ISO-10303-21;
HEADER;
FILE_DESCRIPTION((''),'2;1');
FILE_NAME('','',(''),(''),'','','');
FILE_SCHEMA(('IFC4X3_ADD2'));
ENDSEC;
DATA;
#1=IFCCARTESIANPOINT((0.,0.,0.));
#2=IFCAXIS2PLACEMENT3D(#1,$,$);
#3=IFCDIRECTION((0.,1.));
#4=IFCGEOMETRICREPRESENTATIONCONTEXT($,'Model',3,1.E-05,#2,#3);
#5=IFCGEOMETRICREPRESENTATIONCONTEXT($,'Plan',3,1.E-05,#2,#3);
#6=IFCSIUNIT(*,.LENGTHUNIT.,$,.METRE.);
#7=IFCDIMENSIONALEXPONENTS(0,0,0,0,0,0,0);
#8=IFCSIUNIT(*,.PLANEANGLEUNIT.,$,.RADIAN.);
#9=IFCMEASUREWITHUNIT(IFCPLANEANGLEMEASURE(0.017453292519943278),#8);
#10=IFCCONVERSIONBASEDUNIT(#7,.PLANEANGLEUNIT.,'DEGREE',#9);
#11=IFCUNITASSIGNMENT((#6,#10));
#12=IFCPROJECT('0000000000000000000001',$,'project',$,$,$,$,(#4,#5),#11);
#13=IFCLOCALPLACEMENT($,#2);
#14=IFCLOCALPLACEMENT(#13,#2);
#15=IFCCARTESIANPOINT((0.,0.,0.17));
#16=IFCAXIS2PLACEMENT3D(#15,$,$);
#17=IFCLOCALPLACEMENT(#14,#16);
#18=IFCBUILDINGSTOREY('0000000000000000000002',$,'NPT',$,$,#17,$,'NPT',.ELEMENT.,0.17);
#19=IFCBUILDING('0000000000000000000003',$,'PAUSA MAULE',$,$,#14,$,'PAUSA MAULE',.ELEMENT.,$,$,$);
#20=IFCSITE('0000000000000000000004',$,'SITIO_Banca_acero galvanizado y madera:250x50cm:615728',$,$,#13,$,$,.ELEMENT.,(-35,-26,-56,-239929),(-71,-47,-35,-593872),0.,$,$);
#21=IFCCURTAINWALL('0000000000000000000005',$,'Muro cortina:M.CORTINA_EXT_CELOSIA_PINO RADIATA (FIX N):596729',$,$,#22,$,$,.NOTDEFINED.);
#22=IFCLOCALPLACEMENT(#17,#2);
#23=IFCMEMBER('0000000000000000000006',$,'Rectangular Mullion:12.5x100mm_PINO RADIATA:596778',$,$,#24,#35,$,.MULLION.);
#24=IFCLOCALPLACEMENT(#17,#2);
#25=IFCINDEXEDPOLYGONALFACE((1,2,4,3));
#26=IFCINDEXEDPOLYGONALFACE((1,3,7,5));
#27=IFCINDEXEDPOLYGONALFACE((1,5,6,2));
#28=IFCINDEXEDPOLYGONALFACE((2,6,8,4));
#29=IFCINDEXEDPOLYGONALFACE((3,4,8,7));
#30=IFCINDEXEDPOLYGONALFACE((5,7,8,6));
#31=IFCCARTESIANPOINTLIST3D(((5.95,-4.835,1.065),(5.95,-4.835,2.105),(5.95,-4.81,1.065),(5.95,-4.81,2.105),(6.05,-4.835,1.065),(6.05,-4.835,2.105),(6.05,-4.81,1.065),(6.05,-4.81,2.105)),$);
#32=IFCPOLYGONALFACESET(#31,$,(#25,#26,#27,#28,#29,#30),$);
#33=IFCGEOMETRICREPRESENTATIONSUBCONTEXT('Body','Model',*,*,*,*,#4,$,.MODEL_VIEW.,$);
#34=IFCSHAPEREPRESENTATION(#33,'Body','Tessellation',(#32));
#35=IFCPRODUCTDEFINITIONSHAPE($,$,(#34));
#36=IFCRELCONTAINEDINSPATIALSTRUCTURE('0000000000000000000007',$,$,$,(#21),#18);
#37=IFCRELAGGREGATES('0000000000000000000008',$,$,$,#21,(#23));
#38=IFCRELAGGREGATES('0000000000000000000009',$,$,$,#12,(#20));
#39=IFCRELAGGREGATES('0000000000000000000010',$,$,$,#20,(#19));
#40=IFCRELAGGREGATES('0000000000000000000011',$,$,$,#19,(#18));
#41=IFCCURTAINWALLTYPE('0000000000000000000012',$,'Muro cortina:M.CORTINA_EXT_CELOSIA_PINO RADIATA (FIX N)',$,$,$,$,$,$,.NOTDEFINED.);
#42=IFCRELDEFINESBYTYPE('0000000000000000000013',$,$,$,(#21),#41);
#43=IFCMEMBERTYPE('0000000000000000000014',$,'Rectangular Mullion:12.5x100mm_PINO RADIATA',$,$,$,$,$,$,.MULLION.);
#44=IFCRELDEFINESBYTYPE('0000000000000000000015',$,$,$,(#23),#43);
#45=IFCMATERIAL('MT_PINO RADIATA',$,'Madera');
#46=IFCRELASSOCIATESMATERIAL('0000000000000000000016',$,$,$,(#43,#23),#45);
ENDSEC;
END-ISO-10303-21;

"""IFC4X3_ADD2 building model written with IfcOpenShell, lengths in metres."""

from ifc_helpers import new_model, entity, si_unit, converted_unit, direction, frame, frame_2d, origin, origin_2d_with_axis, place, context, subcontext, project, spatial, rectangle, extrude, source, transform, mapped, material, material_profile, profile_set, profile_usage, type_object, type_shapes, element, aggregate, save


model = new_model("IFC4X3_ADD2")

# Units and contexts
model_context = context("Model", 3, precision=1e-05, world=origin(), true_north=direction((0.0, 1.0)))
plan_context = context("Plan", 3, precision=1e-05, world=origin(), true_north=direction((0.0, 1.0)))
body_context = subcontext(model_context, "Body", "Model", "MODEL_VIEW")
ifc_project = project(units=[si_unit("LENGTHUNIT", "METRE"), converted_unit("PLANEANGLEUNIT", "DEGREE", entity("IfcPlaneAngleMeasure", 0.017453292519943278), si_unit("PLANEANGLEUNIT", "RADIAN"), dimensions=[0, 0, 0, 0, 0, 0, 0])], contexts=[model_context, plan_context])

# Site, building, storey
site_placement = place(None, origin())
site = spatial("IfcSite", under=ifc_project, at=site_placement, Name="SITIO_Banca_acero galvanizado y madera:250x50cm:615728", CompositionType="ELEMENT", RefLatitude=(-35, -26, -56, -239929), RefLongitude=(-71, -47, -35, -593872), RefElevation=0.0)
building_placement = place(site_placement, origin())
building = spatial("IfcBuilding", under=site, at=building_placement, Name="PAUSA MAULE", LongName="PAUSA MAULE", CompositionType="ELEMENT")
storey_placement = place(building_placement, frame((0.0, 0.0, 0.17)))
storey = spatial("IfcBuildingStorey", under=building, at=storey_placement, Name="NPT", LongName="NPT", CompositionType="ELEMENT", Elevation=0.17)

# Curtain wall
curtain_wall_type = type_object("IfcCurtainWallType", Name="Muro cortina:M.CORTINA_EXT_CELOSIA_PINO RADIATA (FIX N)", PredefinedType="NOTDEFINED")
curtain_wall_1_placement = place(storey_placement, frame((0.0, 0.0, -0.17)))
curtain_wall_1 = element("IfcCurtainWall", 1, at=curtain_wall_1_placement, inside=storey, type_object=curtain_wall_type, Name="Muro cortina:M.CORTINA_EXT_CELOSIA_PINO RADIATA (FIX N):596729", PredefinedType="NOTDEFINED")
ifc_material = material(Name="MT_PINO RADIATA", Category="Madera")
ifc_material_profile = material_profile(ifc_material, rectangle(XDim=0.025, YDim=0.1, at=frame_2d((0.0, 0.0), x_axis=(1.0, 0.0))), Name="12.5x100mm_PINO RADIATA")
ifc_profile_set = profile_set([ifc_material_profile], Name="12.5x100mm_PINO RADIATA")
ifc_profile_usage = profile_usage(ifc_profile_set)

# Member
member_type_1 = type_object("IfcMemberType", Name="Rectangular Mullion:12.5x100mm_PINO RADIATA", PredefinedType="MULLION", material=ifc_profile_set)
shared_shape_1 = source(origin(), body_context, "Body", "SweptSolid", [
    extrude(rectangle(XDim=0.025, YDim=0.1, at=origin_2d_with_axis()), frame((-0.0125, 0.0, -1.04), z_axis=(0.0, 0.0, 1.0), x_axis=(-1.0, 0.0, 0.0)), (0.0, 0.0, 1.0), 1.04),
])
type_shapes(member_type_1, [shared_shape_1])
member_1_placement = place(curtain_wall_1_placement, frame((6.0, -4.835, 1.235), z_axis=(0.0, 0.0, -1.0), x_axis=(0.0, -1.0, 0.0)))
member_1 = element("IfcMember", 2, at=member_1_placement, type_object=member_type_1, material=ifc_profile_usage, Name="Rectangular Mullion:12.5x100mm_PINO RADIATA:596778", PredefinedType="MULLION", context=body_context, shape_type="MappedRepresentation", body=[
    mapped(shared_shape_1, transform((0.0, 0.0, 0.0), scale=1.0)),
])
aggregate(curtain_wall_1, [member_1])

save(model, "model.ifc")
